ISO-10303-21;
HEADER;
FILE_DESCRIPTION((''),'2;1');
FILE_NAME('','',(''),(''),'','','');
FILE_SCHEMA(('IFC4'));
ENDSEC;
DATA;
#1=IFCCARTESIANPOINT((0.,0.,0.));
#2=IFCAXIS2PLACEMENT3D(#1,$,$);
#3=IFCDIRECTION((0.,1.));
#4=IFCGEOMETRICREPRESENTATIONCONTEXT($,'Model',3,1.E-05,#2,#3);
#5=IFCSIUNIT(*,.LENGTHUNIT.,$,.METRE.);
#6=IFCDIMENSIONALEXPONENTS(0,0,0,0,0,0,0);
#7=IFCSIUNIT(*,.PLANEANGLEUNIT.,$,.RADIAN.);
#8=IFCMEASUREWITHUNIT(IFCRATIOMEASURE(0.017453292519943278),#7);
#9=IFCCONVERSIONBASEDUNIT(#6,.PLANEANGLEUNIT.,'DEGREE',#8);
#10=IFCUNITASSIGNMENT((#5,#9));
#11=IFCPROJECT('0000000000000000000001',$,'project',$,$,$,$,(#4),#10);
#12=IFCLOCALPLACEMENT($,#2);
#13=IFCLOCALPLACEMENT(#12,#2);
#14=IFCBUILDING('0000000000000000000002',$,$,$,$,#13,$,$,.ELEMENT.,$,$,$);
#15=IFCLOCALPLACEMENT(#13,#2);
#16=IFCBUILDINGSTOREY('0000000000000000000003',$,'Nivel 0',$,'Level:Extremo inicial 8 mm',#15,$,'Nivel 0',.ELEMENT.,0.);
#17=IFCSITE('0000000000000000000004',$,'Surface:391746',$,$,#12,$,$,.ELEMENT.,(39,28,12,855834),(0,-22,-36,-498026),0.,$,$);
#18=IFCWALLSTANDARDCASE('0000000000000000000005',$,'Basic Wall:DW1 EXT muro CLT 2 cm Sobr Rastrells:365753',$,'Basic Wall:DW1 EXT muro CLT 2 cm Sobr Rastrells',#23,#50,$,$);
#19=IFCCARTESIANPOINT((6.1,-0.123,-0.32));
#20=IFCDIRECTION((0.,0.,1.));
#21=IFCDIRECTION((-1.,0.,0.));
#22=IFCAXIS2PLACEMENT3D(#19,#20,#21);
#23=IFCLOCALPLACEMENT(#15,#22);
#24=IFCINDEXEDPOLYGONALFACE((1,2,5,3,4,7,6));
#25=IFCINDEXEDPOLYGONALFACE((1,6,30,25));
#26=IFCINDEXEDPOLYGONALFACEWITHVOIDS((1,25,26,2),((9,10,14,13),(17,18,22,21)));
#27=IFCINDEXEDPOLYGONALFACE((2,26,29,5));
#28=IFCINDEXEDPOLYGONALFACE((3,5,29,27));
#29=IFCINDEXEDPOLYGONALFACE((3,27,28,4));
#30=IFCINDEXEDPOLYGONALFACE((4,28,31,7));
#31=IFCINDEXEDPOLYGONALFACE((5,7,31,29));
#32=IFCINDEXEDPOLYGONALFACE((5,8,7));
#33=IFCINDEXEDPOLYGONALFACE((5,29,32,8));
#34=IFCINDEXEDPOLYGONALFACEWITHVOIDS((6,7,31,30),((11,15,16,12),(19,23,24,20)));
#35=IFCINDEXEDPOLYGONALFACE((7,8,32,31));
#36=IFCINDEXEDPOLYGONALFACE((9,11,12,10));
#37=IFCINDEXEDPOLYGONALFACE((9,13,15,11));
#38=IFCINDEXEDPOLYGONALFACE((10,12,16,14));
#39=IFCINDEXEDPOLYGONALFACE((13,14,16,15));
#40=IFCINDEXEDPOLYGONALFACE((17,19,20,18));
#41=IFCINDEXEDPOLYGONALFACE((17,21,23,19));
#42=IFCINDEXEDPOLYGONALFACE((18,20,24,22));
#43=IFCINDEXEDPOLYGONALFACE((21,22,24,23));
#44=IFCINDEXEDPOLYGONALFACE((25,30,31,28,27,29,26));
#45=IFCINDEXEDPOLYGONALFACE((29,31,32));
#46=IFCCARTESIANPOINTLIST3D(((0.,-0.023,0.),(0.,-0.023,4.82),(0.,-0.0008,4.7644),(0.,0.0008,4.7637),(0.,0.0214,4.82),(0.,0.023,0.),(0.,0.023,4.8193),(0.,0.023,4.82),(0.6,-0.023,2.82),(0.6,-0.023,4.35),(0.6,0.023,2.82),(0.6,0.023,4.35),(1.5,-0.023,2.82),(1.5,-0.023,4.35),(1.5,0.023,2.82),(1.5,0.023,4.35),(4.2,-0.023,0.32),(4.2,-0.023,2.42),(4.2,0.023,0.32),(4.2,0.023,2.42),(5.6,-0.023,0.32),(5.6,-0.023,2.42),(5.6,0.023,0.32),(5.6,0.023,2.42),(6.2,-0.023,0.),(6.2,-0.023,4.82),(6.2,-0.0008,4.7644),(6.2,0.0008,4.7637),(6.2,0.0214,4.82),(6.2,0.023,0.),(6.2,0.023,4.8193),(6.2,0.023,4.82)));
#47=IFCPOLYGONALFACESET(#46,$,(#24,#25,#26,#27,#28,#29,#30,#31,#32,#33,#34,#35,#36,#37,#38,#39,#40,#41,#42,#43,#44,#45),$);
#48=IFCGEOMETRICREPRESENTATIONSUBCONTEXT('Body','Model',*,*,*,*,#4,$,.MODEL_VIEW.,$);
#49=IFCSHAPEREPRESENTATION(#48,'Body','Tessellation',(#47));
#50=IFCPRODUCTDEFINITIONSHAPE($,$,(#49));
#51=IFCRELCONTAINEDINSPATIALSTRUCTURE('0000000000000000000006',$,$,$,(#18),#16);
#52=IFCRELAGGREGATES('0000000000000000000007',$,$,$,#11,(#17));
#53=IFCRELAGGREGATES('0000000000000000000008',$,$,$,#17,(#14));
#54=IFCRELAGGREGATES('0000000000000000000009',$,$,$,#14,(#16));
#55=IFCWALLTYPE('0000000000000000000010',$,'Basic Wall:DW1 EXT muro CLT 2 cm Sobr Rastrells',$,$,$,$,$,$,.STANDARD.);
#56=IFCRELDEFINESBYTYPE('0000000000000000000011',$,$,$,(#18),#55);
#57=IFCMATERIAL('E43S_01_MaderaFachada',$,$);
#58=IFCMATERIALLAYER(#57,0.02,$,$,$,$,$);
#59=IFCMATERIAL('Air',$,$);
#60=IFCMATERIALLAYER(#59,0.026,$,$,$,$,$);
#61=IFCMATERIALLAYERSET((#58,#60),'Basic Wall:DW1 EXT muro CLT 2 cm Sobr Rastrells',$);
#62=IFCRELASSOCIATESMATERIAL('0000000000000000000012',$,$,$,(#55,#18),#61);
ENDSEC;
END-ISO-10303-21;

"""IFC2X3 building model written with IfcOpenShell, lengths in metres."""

from ifc_helpers import new_model, entity, si_unit, converted_unit, direction, frame, frame_2d, origin, origin_2d_with_axis, place, context, subcontext, project, spatial, rectangle, extrude, material, layer, layer_set, layer_usage, type_object, element, save


model = new_model("IFC2X3")

# Units and contexts
model_context = context("Model", 3, precision=1e-05, world=origin(), true_north=direction((0.0, 1.0)))
body_context = subcontext(model_context, "Body", "Model", "MODEL_VIEW")
ifc_project = project(units=[si_unit("LENGTHUNIT", "METRE"), converted_unit("PLANEANGLEUNIT", "DEGREE", entity("IfcRatioMeasure", 0.017453292519943278), si_unit("PLANEANGLEUNIT", "RADIAN"), dimensions=[0, 0, 0, 0, 0, 0, 0])], contexts=[model_context])

# Site, building, storey
site_placement = place(None, origin())
site = spatial("IfcSite", under=ifc_project, at=site_placement, Name="Surface:391746", CompositionType="ELEMENT", RefLatitude=(39, 28, 12, 855834), RefLongitude=(0, -22, -36, -498026), RefElevation=0.0)
building_placement = place(site_placement, origin())
building = spatial("IfcBuilding", under=site, at=building_placement, CompositionType="ELEMENT")
storey_placement = place(building_placement, origin())
storey = spatial("IfcBuildingStorey", under=building, at=storey_placement, Name="Nivel 0", ObjectType="Level:Extremo inicial 8 mm", LongName="Nivel 0", CompositionType="ELEMENT", Elevation=0.0)

# Wall, openings
ifc_material_1 = material(Name="E43S_01_MaderaFachada")
ifc_layer_1 = layer(ifc_material_1, 0.02)
ifc_material_2 = material(Name="Air")
ifc_layer_2 = layer(ifc_material_2, 0.026)
ifc_layer_set = layer_set([ifc_layer_1, ifc_layer_2], Name="Basic Wall:DW1 EXT muro CLT 2 cm Sobr Rastrells")
ifc_layer_usage = layer_usage(ifc_layer_set, "AXIS2", "NEGATIVE", 0.023)
wall_type = type_object("IfcWallType", Name="Basic Wall:DW1 EXT muro CLT 2 cm Sobr Rastrells", PredefinedType="STANDARD", material=ifc_layer_set)
wall_placement = place(storey_placement, frame((6.1, -0.123, -0.32), z_axis=(0.0, 0.0, 1.0), x_axis=(-1.0, 0.0, 0.0)))
wall = element("IfcWallStandardCase", 1, at=wall_placement, inside=storey, type_object=wall_type, material=ifc_layer_usage, Name="Basic Wall:DW1 EXT muro CLT 2 cm Sobr Rastrells:365753", ObjectType="Basic Wall:DW1 EXT muro CLT 2 cm Sobr Rastrells", context=body_context, shape_type="SweptSolid", body=[
    extrude(rectangle(XDim=6.2, YDim=0.046, at=frame_2d((3.1, 0.0), x_axis=(-1.0, 0.0))), origin(), (0.0, 0.0, 1.0), 4.82),
])
opening_1_placement = place(storey_placement, frame((6.1, -0.123, -0.32), z_axis=(0.0, 0.0, 1.0), x_axis=(-1.0, 0.0, 0.0)))
element("IfcOpeningElement", 2, at=opening_1_placement, cuts=wall, ObjectType="Opening", context=body_context, shape_type="SweptSolid", body=[
    extrude(rectangle(XDim=0.0018, YDim=6.2, at=frame_2d((0.0, 0.0), x_axis=(0.0, 1.0))), frame((3.1, 0.0222, 4.8197), z_axis=(0.0, -0.370288, -0.928917), x_axis=(1.0, 0.0, 0.0)), (0.0, 0.0, 1.0), 0.0599),
])
opening_2_placement = place(wall_placement, origin())
element("IfcOpeningElement", 3, at=opening_2_placement, cuts=wall, ObjectType="Opening", context=body_context, shape_type="SweptSolid", body=[
    extrude(rectangle(XDim=1.53, YDim=0.9, at=frame_2d((0.0, 0.0), x_axis=(1.0, 0.0))), frame((1.05, -1.547, 3.585), z_axis=(0.0, 1.0, 0.0), x_axis=(0.0, 0.0, -1.0)), (0.0, 0.0, 1.0), 3.048),
])
opening_3_placement = place(wall_placement, origin())
element("IfcOpeningElement", 4, at=opening_3_placement, cuts=wall, ObjectType="Opening", context=body_context, shape_type="SweptSolid", body=[
    extrude(rectangle(XDim=2.1, YDim=1.4, at=origin_2d_with_axis()), frame((4.9, -1.547, 1.37), z_axis=(0.0, 1.0, 0.0), x_axis=(0.0, 0.0, -1.0)), (0.0, 0.0, 1.0), 3.048),
])

save(model, "model.ifc")
